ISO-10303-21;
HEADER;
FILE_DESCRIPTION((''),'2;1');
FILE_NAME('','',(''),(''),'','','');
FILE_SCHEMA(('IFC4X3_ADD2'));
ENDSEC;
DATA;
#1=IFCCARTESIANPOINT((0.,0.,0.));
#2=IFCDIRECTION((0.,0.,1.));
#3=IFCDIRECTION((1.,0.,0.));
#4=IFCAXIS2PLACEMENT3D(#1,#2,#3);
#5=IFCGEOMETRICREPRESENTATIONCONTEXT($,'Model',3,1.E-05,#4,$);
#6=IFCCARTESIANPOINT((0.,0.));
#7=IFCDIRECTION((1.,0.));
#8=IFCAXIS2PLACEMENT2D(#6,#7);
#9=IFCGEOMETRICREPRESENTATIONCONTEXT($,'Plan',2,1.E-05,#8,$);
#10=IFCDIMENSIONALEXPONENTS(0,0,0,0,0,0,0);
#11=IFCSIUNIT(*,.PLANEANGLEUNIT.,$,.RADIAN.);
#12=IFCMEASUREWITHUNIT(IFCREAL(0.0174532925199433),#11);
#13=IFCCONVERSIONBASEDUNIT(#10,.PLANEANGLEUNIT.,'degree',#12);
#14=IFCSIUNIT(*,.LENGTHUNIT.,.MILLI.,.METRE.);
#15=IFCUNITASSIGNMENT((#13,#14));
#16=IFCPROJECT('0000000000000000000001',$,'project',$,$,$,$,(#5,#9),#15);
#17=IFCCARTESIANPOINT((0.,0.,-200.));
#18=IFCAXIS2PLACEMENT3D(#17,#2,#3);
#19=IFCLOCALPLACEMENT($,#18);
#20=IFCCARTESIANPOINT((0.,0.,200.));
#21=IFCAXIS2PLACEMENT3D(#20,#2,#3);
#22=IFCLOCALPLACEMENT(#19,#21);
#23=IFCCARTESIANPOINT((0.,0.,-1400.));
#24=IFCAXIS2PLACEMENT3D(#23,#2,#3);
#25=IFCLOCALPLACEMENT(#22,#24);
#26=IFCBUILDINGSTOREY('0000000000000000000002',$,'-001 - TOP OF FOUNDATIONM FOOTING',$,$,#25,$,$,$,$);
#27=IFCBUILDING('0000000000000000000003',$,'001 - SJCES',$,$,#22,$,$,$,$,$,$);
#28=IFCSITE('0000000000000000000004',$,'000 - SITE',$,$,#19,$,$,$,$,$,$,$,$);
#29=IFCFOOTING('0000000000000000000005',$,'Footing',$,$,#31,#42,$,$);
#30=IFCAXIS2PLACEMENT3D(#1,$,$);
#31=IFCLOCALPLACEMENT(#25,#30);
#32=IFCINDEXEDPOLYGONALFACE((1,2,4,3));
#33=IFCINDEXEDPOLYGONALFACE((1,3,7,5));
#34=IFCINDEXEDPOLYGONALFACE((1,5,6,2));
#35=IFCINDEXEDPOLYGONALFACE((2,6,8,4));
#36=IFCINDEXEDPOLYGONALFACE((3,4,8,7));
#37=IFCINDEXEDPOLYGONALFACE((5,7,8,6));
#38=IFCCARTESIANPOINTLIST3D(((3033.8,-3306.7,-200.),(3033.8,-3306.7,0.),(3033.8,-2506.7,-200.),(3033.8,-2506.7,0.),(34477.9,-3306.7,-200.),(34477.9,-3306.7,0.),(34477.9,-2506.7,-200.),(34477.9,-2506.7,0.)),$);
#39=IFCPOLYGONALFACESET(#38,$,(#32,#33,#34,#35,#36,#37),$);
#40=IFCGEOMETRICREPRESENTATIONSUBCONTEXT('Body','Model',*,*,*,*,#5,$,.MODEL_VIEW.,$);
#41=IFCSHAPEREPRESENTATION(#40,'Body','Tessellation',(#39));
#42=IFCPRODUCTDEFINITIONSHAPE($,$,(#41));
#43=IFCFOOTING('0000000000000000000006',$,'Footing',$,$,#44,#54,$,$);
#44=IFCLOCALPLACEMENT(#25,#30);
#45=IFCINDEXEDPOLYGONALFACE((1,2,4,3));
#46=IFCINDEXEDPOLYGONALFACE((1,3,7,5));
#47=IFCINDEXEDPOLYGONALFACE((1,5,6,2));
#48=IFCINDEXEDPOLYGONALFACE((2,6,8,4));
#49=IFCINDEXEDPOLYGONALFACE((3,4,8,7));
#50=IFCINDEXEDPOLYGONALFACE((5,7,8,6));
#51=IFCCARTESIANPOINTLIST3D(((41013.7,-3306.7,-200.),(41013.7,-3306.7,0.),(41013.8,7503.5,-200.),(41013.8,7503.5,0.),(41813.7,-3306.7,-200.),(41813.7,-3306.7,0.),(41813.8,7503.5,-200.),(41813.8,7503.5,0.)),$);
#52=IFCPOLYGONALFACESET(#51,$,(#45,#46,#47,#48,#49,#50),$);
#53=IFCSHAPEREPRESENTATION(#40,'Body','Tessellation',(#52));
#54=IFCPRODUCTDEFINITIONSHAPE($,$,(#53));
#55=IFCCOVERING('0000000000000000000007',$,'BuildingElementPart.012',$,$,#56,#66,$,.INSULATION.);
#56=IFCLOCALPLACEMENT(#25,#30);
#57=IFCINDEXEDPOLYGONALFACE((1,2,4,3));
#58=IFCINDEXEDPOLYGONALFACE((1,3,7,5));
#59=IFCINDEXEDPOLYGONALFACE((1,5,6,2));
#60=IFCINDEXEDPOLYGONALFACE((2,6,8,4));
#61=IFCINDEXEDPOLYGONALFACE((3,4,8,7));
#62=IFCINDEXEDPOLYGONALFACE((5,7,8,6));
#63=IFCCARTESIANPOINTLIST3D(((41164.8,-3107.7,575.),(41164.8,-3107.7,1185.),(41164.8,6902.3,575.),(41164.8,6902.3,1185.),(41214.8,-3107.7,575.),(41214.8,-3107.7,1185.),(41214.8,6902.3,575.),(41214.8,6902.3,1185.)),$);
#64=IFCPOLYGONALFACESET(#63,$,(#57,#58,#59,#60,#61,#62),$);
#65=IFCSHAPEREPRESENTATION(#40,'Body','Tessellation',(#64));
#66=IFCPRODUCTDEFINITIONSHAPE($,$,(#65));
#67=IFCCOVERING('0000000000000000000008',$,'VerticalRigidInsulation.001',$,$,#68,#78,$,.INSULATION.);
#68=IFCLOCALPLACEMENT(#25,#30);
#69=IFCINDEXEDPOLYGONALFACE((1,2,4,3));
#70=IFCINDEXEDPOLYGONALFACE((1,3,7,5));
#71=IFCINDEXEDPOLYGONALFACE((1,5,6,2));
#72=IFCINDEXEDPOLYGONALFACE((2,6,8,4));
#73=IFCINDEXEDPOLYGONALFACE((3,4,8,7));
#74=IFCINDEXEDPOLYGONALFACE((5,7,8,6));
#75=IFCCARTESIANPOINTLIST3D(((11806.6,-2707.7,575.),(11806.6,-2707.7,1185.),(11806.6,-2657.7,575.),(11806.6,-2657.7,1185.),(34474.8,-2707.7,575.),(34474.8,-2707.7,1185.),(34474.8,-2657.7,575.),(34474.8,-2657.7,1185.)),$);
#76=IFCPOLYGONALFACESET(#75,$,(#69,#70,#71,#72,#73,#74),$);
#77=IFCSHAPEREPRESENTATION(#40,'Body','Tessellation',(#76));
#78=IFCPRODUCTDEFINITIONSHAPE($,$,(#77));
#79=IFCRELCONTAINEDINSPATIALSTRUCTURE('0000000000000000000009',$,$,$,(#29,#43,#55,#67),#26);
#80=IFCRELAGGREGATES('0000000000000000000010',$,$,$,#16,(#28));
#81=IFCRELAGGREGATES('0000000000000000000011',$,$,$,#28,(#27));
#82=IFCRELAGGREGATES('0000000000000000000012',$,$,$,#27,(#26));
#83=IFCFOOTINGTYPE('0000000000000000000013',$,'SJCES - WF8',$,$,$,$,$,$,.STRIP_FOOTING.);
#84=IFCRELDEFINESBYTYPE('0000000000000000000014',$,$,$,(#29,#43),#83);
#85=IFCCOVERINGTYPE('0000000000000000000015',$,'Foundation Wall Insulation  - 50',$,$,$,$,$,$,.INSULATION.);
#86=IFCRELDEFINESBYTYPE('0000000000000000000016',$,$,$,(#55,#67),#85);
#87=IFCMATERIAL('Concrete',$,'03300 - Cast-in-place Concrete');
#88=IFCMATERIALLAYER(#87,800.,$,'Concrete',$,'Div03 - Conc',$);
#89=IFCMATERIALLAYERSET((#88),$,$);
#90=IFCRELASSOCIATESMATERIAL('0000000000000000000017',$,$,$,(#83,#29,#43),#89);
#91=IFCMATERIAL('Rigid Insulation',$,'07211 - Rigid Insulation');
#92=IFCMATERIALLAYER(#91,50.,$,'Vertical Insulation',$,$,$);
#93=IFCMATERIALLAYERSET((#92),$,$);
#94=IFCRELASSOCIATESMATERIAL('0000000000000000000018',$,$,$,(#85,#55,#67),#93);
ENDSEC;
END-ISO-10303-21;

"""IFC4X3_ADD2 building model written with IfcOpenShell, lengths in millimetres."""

from ifc_helpers import new_model, entity, si_unit, converted_unit, frame, origin_with_axes, origin_2d_with_axis, place, context, subcontext, project, spatial, indexed_curve, outline, extrude, material, layer, layer_set, layer_usage, type_object, element, save


model = new_model("IFC4X3_ADD2")

# Units and contexts
model_context = context("Model", 3, precision=1e-05, world=origin_with_axes())
plan_context = context("Plan", 2, precision=1e-05, world=origin_2d_with_axis())
body_context = subcontext(model_context, "Body", "Model", "MODEL_VIEW")
ifc_project = project(units=[converted_unit("PLANEANGLEUNIT", "degree", entity("IfcReal", 0.0174532925199433), si_unit("PLANEANGLEUNIT", "RADIAN"), dimensions=[0, 0, 0, 0, 0, 0, 0]), si_unit("LENGTHUNIT", "METRE", prefix="MILLI")], contexts=[model_context, plan_context])

# Site, building, storey
site_placement = place(None, frame((0.0, 0.0, -200.0), z_axis=(0.0, 0.0, 1.0), x_axis=(1.0, 0.0, 0.0)))
site = spatial("IfcSite", under=ifc_project, at=site_placement, Name="000 - SITE")
building_placement = place(site_placement, frame((0.0, 0.0, 200.0), z_axis=(0.0, 0.0, 1.0), x_axis=(1.0, 0.0, 0.0)))
building = spatial("IfcBuilding", under=site, at=building_placement, Name="001 - SJCES")
storey_placement = place(building_placement, frame((0.0, 0.0, -1400.0), z_axis=(0.0, 0.0, 1.0), x_axis=(1.0, 0.0, 0.0)))
storey = spatial("IfcBuildingStorey", under=building, at=storey_placement, Name="-001 - TOP OF FOUNDATIONM FOOTING")

# Footings
ifc_material_1 = material(Name="Concrete", Category="03300 - Cast-in-place Concrete")
ifc_layer_1 = layer(ifc_material_1, 800.0, Name="Concrete", Category="Div03 - Conc")
ifc_layer_set_1 = layer_set([ifc_layer_1])
ifc_layer_usage_1 = layer_usage(ifc_layer_set_1, "AXIS2", "POSITIVE", 0.0)
footing_type = type_object("IfcFootingType", Name="SJCES - WF8", PredefinedType="STRIP_FOOTING", material=ifc_layer_set_1)
footing_1_placement = place(storey_placement, frame((3033.8, -3306.7, -200.0), z_axis=(0.0, 0.0, 1.0), x_axis=(1.0, 0.0, 0.0)))
element("IfcFooting", 1, at=footing_1_placement, inside=storey, type_object=footing_type, material=ifc_layer_usage_1, Name="Footing", context=body_context, shape_type="SweptSolid", body=[
    extrude(outline(indexed_curve([(0.0, 0.0), (0.0, 800.0), (31444.1, 800.0), (31444.1, 0.0), (0.0, 0.0)], self_intersect=False)), origin_with_axes(), (0.0, 0.0, 1.0), 200.0),
])
ifc_layer_usage_2 = layer_usage(ifc_layer_set_1, "AXIS2", "POSITIVE", 0.0)
footing_2_placement = place(storey_placement, frame((41813.7, -3306.7, -200.0), z_axis=(0.0, 0.0, 1.0), x_axis=(0.0, 1.0, 0.0)))
element("IfcFooting", 2, at=footing_2_placement, inside=storey, type_object=footing_type, material=ifc_layer_usage_2, Name="Footing", context=body_context, shape_type="SweptSolid", body=[
    extrude(outline(indexed_curve([(0.0, 0.0), (0.0, 800.0), (10810.2, 800.0), (10810.2, 0.0), (0.0, 0.0)], self_intersect=False)), origin_with_axes(), (0.0, 0.0, 1.0), 200.0),
])

# Coverings
ifc_material_2 = material(Name="Rigid Insulation", Category="07211 - Rigid Insulation")
ifc_layer_2 = layer(ifc_material_2, 50.0, Name="Vertical Insulation")
ifc_layer_set_2 = layer_set([ifc_layer_2])
covering_type = type_object("IfcCoveringType", Name="Foundation Wall Insulation  - 50", PredefinedType="INSULATION", material=ifc_layer_set_2)
ifc_layer_usage_3 = layer_usage(ifc_layer_set_2, "AXIS2", "POSITIVE", 0.0)
covering_1_placement = place(storey_placement, frame((41214.8, -3107.7, 575.0), z_axis=(0.0, 0.0, 1.0), x_axis=(0.0, 1.0, 0.0)))
element("IfcCovering", 3, at=covering_1_placement, inside=storey, type_object=covering_type, material=ifc_layer_usage_3, Name="BuildingElementPart.012", PredefinedType="INSULATION", context=body_context, shape_type="SweptSolid", body=[
    extrude(outline(indexed_curve([(0.0, 0.0), (0.0, 50.0), (10010.0, 50.0), (10010.0, 0.0), (0.0, 0.0)], self_intersect=False)), origin_with_axes(), (0.0, 0.0, 1.0), 610.0),
])
ifc_layer_usage_4 = layer_usage(ifc_layer_set_2, "AXIS2", "POSITIVE", 0.0)
covering_2_placement = place(storey_placement, frame((11806.6, -2707.7, 575.0), z_axis=(0.0, 0.0, 1.0), x_axis=(1.0, 0.0, 0.0)))
element("IfcCovering", 4, at=covering_2_placement, inside=storey, type_object=covering_type, material=ifc_layer_usage_4, Name="VerticalRigidInsulation.001", PredefinedType="INSULATION", context=body_context, shape_type="SweptSolid", body=[
    extrude(outline(indexed_curve([(0.0, 0.0), (0.0, 50.0), (22668.2, 50.0), (22668.2, 0.0), (0.0, 0.0)], self_intersect=False)), origin_with_axes(), (0.0, 0.0, 1.0), 610.0),
])

save(model, "model.ifc")
